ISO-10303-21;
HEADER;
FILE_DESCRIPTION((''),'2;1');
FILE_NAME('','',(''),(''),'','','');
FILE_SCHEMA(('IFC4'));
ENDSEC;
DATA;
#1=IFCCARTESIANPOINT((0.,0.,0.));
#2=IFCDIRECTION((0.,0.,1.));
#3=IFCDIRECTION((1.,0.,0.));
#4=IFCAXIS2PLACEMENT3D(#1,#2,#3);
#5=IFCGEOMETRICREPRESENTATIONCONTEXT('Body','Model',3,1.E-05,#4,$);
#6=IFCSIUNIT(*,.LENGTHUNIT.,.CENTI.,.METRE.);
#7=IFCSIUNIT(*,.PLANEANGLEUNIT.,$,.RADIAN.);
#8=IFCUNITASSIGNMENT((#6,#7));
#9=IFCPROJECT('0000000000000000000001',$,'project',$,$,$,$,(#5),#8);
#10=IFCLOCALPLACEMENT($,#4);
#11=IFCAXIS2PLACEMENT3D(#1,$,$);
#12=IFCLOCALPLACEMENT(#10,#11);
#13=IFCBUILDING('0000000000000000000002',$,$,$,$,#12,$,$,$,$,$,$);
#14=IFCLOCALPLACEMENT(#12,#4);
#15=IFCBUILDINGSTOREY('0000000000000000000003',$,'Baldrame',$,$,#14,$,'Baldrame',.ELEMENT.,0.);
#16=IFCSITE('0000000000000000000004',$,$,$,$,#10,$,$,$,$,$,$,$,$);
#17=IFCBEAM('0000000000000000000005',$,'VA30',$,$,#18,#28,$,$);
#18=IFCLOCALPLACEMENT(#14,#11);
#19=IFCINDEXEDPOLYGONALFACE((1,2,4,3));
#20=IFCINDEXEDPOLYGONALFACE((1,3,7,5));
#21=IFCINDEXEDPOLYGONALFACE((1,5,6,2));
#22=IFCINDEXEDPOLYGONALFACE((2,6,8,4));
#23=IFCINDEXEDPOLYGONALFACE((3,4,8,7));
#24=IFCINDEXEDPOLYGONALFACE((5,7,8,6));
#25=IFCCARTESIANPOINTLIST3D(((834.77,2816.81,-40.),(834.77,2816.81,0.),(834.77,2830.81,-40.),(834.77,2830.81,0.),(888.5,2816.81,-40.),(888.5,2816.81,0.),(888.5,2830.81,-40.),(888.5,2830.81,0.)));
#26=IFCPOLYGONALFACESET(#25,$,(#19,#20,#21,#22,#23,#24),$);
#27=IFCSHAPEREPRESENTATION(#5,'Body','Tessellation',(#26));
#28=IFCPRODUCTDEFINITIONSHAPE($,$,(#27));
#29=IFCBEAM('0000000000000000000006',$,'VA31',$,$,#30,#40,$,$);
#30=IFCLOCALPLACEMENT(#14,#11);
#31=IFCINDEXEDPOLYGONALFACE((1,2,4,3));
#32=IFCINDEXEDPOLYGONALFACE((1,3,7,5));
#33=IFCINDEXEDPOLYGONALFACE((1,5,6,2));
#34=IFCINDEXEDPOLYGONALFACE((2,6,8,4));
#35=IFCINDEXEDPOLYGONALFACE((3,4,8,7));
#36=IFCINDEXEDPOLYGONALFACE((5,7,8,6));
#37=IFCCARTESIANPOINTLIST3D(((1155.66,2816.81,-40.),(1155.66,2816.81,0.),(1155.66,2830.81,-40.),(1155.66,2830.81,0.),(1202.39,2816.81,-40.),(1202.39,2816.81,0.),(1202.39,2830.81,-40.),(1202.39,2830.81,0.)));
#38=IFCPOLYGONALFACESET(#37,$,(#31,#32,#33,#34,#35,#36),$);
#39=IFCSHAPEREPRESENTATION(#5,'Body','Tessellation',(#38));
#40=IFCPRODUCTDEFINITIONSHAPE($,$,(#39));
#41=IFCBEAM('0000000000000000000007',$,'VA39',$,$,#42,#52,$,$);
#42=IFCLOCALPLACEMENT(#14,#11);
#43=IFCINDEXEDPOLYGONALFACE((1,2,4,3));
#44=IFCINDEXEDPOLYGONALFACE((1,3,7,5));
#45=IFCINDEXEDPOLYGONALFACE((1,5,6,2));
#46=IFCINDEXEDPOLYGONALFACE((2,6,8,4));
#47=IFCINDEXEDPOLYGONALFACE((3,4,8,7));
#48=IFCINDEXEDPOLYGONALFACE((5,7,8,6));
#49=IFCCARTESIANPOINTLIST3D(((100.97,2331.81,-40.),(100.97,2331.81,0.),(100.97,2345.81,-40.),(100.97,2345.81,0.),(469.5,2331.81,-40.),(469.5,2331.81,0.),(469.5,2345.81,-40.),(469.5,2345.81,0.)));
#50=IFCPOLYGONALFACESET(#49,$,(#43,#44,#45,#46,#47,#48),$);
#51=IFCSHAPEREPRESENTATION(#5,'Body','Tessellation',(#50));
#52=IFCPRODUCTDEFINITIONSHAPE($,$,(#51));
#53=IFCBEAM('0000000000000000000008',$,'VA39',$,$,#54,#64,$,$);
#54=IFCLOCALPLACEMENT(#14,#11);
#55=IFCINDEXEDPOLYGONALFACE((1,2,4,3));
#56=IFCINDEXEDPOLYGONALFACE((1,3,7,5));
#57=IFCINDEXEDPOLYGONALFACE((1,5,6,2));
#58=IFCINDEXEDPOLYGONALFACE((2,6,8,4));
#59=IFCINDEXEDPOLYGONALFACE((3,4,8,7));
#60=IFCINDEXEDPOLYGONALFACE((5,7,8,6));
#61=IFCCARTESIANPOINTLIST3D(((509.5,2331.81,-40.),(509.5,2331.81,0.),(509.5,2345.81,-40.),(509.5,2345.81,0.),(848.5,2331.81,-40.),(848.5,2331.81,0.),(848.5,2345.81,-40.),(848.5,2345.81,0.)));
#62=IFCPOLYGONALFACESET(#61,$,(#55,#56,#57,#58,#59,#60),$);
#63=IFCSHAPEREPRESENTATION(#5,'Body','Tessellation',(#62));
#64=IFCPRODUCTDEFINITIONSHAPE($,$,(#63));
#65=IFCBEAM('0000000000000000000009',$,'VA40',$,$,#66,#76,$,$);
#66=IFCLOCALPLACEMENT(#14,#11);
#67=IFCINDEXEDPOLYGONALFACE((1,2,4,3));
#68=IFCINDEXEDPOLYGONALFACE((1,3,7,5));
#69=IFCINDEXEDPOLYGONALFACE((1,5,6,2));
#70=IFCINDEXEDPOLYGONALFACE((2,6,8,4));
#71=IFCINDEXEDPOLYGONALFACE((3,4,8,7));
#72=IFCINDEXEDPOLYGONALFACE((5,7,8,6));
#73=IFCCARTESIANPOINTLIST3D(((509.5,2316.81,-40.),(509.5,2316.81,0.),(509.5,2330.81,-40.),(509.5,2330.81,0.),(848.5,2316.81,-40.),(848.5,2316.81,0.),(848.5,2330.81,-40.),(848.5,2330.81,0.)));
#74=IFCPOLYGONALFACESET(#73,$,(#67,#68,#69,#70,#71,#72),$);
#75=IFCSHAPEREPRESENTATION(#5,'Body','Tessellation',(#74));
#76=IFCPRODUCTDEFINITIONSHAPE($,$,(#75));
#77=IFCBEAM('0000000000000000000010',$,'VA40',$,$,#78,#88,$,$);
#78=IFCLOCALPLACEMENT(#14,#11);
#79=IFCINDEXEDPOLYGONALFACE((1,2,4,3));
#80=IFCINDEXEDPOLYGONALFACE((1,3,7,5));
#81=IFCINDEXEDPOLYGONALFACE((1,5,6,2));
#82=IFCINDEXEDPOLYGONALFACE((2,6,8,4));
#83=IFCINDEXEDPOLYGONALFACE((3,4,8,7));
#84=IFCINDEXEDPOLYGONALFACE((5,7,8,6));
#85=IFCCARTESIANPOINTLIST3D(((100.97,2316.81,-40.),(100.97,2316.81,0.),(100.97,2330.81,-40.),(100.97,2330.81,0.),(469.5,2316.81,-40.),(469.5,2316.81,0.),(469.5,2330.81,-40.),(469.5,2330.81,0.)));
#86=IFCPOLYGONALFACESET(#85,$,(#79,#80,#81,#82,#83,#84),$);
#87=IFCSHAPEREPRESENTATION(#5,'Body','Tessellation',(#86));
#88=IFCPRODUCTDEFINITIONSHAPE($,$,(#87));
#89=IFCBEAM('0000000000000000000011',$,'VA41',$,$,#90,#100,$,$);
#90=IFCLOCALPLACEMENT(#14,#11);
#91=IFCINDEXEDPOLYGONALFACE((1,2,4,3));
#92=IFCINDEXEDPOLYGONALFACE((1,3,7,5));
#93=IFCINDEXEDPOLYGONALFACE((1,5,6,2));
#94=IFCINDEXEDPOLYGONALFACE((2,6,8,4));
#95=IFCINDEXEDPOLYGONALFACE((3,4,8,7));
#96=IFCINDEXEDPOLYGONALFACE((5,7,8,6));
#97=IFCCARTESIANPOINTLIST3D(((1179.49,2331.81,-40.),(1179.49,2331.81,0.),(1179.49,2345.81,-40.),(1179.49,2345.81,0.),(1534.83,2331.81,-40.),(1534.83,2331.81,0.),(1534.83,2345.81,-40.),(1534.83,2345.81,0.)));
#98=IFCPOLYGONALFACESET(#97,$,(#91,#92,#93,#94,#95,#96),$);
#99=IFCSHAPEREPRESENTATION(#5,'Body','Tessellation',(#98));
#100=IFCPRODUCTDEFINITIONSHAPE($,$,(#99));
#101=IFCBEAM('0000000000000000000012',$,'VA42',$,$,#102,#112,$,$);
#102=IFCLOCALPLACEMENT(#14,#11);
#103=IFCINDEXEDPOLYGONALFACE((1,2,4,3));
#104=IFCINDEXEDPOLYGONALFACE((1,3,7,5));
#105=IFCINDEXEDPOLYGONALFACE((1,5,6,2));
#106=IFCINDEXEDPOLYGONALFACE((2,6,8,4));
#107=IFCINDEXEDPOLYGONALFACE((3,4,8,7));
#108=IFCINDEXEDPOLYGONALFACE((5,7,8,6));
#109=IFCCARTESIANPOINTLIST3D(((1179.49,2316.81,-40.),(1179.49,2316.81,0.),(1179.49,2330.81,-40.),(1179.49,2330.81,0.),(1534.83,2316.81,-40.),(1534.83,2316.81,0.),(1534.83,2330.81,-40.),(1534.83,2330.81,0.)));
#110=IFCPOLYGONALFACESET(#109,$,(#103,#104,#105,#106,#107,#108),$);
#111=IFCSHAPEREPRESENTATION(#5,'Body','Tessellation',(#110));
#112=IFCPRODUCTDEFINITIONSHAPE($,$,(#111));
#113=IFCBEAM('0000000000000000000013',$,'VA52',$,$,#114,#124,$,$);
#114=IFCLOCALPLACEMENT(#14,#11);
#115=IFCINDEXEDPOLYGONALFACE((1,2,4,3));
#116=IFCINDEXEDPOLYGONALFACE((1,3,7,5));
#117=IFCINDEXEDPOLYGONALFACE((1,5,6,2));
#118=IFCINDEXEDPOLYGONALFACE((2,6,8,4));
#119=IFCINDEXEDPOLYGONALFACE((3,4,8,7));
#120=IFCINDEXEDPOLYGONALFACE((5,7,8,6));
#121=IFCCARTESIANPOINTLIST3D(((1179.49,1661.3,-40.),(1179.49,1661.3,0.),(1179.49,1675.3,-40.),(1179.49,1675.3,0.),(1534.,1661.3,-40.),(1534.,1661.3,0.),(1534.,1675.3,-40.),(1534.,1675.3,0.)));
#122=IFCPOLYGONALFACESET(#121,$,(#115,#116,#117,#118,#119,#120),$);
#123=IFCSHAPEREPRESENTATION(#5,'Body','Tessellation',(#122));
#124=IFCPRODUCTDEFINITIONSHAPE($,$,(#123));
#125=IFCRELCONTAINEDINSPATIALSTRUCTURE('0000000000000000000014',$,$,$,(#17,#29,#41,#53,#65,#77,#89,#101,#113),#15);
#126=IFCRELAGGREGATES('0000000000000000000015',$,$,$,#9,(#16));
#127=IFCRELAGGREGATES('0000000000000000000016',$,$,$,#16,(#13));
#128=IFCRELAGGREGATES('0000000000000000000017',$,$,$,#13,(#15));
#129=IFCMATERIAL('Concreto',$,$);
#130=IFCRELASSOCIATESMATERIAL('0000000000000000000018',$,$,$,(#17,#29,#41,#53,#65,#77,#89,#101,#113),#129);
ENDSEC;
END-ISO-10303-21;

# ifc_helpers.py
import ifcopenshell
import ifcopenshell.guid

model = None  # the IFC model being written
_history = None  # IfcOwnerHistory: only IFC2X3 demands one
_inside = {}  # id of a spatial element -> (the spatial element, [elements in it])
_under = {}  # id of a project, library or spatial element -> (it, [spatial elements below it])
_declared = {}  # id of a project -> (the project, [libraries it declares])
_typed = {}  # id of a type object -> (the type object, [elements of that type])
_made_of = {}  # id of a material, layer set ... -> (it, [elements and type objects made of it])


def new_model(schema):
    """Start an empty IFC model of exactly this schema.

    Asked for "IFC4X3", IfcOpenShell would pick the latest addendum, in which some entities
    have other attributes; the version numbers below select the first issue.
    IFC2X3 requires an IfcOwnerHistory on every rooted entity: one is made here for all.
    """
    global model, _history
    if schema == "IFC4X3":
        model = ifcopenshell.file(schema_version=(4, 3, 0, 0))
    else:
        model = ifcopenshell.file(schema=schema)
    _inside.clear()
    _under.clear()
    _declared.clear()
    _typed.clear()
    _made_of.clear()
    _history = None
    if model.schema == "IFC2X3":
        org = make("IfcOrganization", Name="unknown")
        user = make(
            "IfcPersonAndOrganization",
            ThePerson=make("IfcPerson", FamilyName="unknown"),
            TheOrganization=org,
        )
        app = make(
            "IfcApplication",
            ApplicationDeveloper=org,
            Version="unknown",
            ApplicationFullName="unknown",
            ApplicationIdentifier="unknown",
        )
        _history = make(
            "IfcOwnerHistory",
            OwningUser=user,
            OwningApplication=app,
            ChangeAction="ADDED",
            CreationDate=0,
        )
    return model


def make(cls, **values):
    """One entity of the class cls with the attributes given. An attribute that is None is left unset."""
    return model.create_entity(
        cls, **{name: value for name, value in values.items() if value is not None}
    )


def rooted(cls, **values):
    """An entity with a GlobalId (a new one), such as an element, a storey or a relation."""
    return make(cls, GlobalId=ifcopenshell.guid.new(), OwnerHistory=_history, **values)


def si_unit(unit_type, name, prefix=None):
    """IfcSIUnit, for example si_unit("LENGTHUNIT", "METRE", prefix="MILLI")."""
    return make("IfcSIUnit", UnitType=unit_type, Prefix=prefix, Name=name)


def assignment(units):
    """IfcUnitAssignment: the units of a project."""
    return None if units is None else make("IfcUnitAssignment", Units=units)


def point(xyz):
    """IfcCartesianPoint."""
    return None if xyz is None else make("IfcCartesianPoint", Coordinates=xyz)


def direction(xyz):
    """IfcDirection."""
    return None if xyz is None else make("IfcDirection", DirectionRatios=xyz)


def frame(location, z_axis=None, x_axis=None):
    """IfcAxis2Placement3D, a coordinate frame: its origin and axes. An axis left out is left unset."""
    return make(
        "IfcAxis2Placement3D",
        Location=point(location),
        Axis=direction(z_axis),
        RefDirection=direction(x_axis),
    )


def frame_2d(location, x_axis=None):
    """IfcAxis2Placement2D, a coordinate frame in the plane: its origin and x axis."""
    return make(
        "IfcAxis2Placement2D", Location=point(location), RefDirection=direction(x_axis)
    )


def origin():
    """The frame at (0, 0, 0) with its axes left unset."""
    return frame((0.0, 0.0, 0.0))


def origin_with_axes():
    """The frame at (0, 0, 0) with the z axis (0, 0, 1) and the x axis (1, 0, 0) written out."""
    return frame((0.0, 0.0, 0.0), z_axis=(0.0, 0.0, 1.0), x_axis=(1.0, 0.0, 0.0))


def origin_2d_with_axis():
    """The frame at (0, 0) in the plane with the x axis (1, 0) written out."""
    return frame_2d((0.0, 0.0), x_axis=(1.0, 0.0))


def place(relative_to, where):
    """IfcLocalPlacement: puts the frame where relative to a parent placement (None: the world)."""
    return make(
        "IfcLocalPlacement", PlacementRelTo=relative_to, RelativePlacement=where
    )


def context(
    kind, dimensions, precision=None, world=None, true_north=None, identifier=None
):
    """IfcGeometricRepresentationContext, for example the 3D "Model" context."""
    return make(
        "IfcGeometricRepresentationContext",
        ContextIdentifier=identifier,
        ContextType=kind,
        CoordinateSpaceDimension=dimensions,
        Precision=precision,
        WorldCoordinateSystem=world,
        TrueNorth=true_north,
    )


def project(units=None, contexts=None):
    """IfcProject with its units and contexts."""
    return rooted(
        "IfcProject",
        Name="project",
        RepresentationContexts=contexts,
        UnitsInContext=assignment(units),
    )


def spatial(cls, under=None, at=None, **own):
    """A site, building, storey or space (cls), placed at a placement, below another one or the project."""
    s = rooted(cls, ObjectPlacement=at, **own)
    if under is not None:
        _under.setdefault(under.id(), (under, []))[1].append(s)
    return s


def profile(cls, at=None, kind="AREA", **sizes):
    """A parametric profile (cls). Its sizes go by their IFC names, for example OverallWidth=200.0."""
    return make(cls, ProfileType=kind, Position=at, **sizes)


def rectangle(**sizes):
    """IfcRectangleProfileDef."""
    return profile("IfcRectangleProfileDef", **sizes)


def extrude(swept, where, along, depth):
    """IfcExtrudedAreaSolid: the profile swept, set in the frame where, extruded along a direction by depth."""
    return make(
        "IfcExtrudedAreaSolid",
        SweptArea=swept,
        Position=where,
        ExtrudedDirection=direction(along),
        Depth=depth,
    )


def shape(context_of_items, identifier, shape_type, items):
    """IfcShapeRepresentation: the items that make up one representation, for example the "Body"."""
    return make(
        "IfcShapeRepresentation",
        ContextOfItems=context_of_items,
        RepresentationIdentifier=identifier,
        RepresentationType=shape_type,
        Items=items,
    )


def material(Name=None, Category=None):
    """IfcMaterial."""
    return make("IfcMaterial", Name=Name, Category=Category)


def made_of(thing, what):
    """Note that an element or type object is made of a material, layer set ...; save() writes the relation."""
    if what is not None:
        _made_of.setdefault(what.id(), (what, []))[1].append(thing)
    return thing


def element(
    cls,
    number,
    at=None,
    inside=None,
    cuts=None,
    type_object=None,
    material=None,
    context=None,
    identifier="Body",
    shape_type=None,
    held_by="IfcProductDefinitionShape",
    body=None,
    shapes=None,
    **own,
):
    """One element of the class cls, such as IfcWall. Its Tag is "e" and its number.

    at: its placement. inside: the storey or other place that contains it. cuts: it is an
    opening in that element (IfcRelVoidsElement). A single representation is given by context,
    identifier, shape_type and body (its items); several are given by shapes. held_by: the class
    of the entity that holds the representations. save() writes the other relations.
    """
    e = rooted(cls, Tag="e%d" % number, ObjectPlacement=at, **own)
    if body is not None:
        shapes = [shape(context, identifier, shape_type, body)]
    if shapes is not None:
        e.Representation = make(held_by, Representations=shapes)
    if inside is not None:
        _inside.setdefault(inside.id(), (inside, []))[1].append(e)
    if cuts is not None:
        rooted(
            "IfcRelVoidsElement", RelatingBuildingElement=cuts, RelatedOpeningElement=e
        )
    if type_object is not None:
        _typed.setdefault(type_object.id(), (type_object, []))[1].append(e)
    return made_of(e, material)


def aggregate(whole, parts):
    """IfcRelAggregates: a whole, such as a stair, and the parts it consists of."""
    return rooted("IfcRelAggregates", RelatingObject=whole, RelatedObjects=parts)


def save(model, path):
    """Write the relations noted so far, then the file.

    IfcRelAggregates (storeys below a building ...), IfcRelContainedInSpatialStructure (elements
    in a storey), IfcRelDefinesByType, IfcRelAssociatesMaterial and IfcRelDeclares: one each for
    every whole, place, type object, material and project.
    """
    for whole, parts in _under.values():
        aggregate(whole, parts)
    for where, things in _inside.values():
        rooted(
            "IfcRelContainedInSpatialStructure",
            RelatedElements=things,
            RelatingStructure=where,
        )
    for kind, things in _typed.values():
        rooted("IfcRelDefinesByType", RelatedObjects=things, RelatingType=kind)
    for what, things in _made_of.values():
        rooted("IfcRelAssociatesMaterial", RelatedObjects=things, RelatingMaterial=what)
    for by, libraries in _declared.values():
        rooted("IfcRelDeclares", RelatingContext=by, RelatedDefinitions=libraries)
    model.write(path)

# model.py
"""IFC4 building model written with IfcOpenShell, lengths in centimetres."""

from ifc_helpers import new_model, si_unit, frame, origin, origin_with_axes, origin_2d_with_axis, place, context, project, spatial, rectangle, extrude, material, element, save


model = new_model("IFC4")

# Units and contexts
model_context = context("Model", 3, precision=1e-05, world=origin_with_axes(), identifier="Body")
ifc_project = project(units=[si_unit("LENGTHUNIT", "METRE", prefix="CENTI"), si_unit("PLANEANGLEUNIT", "RADIAN")], contexts=[model_context])

# Site, building, storey
site_placement = place(None, origin_with_axes())
site = spatial("IfcSite", under=ifc_project, at=site_placement)
building_placement = place(site_placement, origin())
building = spatial("IfcBuilding", under=site, at=building_placement)
storey_placement = place(building_placement, origin_with_axes())
storey = spatial("IfcBuildingStorey", under=building, at=storey_placement, Name="Baldrame", LongName="Baldrame", CompositionType="ELEMENT", Elevation=0.0)

# Shared definitions
ifc_material = material(Name="Concreto")

# Beams
beam_1_placement = place(storey_placement, frame((861.63, 2823.81, 0.0), z_axis=(0.0, 0.0, 1.0), x_axis=(1.0, 0.0, 0.0)))
element("IfcBeam", 1, at=beam_1_placement, inside=storey, material=ifc_material, Name="VA30", context=model_context, shape_type="SolidModel", body=[
    extrude(rectangle(XDim=14.0, YDim=40.0, at=origin_2d_with_axis()), frame((-26.87, 0.0, -20.0), z_axis=(1.0, 0.0, 0.0), x_axis=(0.0, 1.0, 0.0)), (0.0, 0.0, 1.0), 53.73),
])
beam_2_placement = place(storey_placement, frame((1179.03, 2823.81, 0.0), z_axis=(0.0, 0.0, 1.0), x_axis=(1.0, 0.0, 0.0)))
element("IfcBeam", 2, at=beam_2_placement, inside=storey, material=ifc_material, Name="VA31", context=model_context, shape_type="SolidModel", body=[
    extrude(rectangle(XDim=14.0, YDim=40.0, at=origin_2d_with_axis()), frame((-23.37, 0.0, -20.0), z_axis=(1.0, 0.0, 0.0), x_axis=(0.0, 1.0, 0.0)), (0.0, 0.0, 1.0), 46.73),
])
beam_3_placement = place(storey_placement, frame((285.24, 2338.81, 0.0), z_axis=(0.0, 0.0, 1.0), x_axis=(1.0, 0.0, 0.0)))
element("IfcBeam", 3, at=beam_3_placement, inside=storey, material=ifc_material, Name="VA39", context=model_context, shape_type="SolidModel", body=[
    extrude(rectangle(XDim=14.0, YDim=40.0, at=origin_2d_with_axis()), frame((-184.26, 0.0, -20.0), z_axis=(1.0, 0.0, 0.0), x_axis=(0.0, 1.0, 0.0)), (0.0, 0.0, 1.0), 368.53),
])
for number, where, z_axis, x_axis, name in (
    (4, (679.0, 2338.81, 0.0), (0.0, 0.0, 1.0), (1.0, 0.0, 0.0), "VA39"),
    (5, (679.0, 2323.81, 0.0), (0.0, 0.0, 1.0), (1.0, 0.0, 0.0), "VA40"),
):
    element("IfcBeam", number, at=place(storey_placement, frame(where, z_axis=z_axis, x_axis=x_axis)), inside=storey, material=ifc_material, Name=name, context=model_context, shape_type="SolidModel", body=[
        extrude(rectangle(XDim=14.0, YDim=40.0, at=origin_2d_with_axis()), frame((-169.5, 0.0, -20.0), z_axis=(1.0, 0.0, 0.0), x_axis=(0.0, 1.0, 0.0)), (0.0, 0.0, 1.0), 339.0),
    ])
beam_4_placement = place(storey_placement, frame((285.24, 2323.81, 0.0), z_axis=(0.0, 0.0, 1.0), x_axis=(1.0, 0.0, 0.0)))
element("IfcBeam", 6, at=beam_4_placement, inside=storey, material=ifc_material, Name="VA40", context=model_context, shape_type="SolidModel", body=[
    extrude(rectangle(XDim=14.0, YDim=40.0, at=origin_2d_with_axis()), frame((-184.26, 0.0, -20.0), z_axis=(1.0, 0.0, 0.0), x_axis=(0.0, 1.0, 0.0)), (0.0, 0.0, 1.0), 368.53),
])
for number, where, z_axis, x_axis, name in (
    (7, (1357.16, 2338.81, 0.0), (0.0, 0.0, 1.0), (1.0, 0.0, 0.0), "VA41"),
    (8, (1357.16, 2323.81, 0.0), (0.0, 0.0, 1.0), (1.0, 0.0, 0.0), "VA42"),
):
    element("IfcBeam", number, at=place(storey_placement, frame(where, z_axis=z_axis, x_axis=x_axis)), inside=storey, material=ifc_material, Name=name, context=model_context, shape_type="SolidModel", body=[
        extrude(rectangle(XDim=14.0, YDim=40.0, at=origin_2d_with_axis()), frame((-177.67, 0.0, -20.0), z_axis=(1.0, 0.0, 0.0), x_axis=(0.0, 1.0, 0.0)), (0.0, 0.0, 1.0), 355.34),
    ])
beam_5_placement = place(storey_placement, frame((1356.74, 1668.3, 0.0), z_axis=(0.0, 0.0, 1.0), x_axis=(1.0, 0.0, 0.0)))
element("IfcBeam", 9, at=beam_5_placement, inside=storey, material=ifc_material, Name="VA52", context=model_context, shape_type="SolidModel", body=[
    extrude(rectangle(XDim=14.0, YDim=40.0, at=origin_2d_with_axis()), frame((-177.25, 0.0, -20.0), z_axis=(1.0, 0.0, 0.0), x_axis=(0.0, 1.0, 0.0)), (0.0, 0.0, 1.0), 354.51),
])

save(model, "model.ifc")
